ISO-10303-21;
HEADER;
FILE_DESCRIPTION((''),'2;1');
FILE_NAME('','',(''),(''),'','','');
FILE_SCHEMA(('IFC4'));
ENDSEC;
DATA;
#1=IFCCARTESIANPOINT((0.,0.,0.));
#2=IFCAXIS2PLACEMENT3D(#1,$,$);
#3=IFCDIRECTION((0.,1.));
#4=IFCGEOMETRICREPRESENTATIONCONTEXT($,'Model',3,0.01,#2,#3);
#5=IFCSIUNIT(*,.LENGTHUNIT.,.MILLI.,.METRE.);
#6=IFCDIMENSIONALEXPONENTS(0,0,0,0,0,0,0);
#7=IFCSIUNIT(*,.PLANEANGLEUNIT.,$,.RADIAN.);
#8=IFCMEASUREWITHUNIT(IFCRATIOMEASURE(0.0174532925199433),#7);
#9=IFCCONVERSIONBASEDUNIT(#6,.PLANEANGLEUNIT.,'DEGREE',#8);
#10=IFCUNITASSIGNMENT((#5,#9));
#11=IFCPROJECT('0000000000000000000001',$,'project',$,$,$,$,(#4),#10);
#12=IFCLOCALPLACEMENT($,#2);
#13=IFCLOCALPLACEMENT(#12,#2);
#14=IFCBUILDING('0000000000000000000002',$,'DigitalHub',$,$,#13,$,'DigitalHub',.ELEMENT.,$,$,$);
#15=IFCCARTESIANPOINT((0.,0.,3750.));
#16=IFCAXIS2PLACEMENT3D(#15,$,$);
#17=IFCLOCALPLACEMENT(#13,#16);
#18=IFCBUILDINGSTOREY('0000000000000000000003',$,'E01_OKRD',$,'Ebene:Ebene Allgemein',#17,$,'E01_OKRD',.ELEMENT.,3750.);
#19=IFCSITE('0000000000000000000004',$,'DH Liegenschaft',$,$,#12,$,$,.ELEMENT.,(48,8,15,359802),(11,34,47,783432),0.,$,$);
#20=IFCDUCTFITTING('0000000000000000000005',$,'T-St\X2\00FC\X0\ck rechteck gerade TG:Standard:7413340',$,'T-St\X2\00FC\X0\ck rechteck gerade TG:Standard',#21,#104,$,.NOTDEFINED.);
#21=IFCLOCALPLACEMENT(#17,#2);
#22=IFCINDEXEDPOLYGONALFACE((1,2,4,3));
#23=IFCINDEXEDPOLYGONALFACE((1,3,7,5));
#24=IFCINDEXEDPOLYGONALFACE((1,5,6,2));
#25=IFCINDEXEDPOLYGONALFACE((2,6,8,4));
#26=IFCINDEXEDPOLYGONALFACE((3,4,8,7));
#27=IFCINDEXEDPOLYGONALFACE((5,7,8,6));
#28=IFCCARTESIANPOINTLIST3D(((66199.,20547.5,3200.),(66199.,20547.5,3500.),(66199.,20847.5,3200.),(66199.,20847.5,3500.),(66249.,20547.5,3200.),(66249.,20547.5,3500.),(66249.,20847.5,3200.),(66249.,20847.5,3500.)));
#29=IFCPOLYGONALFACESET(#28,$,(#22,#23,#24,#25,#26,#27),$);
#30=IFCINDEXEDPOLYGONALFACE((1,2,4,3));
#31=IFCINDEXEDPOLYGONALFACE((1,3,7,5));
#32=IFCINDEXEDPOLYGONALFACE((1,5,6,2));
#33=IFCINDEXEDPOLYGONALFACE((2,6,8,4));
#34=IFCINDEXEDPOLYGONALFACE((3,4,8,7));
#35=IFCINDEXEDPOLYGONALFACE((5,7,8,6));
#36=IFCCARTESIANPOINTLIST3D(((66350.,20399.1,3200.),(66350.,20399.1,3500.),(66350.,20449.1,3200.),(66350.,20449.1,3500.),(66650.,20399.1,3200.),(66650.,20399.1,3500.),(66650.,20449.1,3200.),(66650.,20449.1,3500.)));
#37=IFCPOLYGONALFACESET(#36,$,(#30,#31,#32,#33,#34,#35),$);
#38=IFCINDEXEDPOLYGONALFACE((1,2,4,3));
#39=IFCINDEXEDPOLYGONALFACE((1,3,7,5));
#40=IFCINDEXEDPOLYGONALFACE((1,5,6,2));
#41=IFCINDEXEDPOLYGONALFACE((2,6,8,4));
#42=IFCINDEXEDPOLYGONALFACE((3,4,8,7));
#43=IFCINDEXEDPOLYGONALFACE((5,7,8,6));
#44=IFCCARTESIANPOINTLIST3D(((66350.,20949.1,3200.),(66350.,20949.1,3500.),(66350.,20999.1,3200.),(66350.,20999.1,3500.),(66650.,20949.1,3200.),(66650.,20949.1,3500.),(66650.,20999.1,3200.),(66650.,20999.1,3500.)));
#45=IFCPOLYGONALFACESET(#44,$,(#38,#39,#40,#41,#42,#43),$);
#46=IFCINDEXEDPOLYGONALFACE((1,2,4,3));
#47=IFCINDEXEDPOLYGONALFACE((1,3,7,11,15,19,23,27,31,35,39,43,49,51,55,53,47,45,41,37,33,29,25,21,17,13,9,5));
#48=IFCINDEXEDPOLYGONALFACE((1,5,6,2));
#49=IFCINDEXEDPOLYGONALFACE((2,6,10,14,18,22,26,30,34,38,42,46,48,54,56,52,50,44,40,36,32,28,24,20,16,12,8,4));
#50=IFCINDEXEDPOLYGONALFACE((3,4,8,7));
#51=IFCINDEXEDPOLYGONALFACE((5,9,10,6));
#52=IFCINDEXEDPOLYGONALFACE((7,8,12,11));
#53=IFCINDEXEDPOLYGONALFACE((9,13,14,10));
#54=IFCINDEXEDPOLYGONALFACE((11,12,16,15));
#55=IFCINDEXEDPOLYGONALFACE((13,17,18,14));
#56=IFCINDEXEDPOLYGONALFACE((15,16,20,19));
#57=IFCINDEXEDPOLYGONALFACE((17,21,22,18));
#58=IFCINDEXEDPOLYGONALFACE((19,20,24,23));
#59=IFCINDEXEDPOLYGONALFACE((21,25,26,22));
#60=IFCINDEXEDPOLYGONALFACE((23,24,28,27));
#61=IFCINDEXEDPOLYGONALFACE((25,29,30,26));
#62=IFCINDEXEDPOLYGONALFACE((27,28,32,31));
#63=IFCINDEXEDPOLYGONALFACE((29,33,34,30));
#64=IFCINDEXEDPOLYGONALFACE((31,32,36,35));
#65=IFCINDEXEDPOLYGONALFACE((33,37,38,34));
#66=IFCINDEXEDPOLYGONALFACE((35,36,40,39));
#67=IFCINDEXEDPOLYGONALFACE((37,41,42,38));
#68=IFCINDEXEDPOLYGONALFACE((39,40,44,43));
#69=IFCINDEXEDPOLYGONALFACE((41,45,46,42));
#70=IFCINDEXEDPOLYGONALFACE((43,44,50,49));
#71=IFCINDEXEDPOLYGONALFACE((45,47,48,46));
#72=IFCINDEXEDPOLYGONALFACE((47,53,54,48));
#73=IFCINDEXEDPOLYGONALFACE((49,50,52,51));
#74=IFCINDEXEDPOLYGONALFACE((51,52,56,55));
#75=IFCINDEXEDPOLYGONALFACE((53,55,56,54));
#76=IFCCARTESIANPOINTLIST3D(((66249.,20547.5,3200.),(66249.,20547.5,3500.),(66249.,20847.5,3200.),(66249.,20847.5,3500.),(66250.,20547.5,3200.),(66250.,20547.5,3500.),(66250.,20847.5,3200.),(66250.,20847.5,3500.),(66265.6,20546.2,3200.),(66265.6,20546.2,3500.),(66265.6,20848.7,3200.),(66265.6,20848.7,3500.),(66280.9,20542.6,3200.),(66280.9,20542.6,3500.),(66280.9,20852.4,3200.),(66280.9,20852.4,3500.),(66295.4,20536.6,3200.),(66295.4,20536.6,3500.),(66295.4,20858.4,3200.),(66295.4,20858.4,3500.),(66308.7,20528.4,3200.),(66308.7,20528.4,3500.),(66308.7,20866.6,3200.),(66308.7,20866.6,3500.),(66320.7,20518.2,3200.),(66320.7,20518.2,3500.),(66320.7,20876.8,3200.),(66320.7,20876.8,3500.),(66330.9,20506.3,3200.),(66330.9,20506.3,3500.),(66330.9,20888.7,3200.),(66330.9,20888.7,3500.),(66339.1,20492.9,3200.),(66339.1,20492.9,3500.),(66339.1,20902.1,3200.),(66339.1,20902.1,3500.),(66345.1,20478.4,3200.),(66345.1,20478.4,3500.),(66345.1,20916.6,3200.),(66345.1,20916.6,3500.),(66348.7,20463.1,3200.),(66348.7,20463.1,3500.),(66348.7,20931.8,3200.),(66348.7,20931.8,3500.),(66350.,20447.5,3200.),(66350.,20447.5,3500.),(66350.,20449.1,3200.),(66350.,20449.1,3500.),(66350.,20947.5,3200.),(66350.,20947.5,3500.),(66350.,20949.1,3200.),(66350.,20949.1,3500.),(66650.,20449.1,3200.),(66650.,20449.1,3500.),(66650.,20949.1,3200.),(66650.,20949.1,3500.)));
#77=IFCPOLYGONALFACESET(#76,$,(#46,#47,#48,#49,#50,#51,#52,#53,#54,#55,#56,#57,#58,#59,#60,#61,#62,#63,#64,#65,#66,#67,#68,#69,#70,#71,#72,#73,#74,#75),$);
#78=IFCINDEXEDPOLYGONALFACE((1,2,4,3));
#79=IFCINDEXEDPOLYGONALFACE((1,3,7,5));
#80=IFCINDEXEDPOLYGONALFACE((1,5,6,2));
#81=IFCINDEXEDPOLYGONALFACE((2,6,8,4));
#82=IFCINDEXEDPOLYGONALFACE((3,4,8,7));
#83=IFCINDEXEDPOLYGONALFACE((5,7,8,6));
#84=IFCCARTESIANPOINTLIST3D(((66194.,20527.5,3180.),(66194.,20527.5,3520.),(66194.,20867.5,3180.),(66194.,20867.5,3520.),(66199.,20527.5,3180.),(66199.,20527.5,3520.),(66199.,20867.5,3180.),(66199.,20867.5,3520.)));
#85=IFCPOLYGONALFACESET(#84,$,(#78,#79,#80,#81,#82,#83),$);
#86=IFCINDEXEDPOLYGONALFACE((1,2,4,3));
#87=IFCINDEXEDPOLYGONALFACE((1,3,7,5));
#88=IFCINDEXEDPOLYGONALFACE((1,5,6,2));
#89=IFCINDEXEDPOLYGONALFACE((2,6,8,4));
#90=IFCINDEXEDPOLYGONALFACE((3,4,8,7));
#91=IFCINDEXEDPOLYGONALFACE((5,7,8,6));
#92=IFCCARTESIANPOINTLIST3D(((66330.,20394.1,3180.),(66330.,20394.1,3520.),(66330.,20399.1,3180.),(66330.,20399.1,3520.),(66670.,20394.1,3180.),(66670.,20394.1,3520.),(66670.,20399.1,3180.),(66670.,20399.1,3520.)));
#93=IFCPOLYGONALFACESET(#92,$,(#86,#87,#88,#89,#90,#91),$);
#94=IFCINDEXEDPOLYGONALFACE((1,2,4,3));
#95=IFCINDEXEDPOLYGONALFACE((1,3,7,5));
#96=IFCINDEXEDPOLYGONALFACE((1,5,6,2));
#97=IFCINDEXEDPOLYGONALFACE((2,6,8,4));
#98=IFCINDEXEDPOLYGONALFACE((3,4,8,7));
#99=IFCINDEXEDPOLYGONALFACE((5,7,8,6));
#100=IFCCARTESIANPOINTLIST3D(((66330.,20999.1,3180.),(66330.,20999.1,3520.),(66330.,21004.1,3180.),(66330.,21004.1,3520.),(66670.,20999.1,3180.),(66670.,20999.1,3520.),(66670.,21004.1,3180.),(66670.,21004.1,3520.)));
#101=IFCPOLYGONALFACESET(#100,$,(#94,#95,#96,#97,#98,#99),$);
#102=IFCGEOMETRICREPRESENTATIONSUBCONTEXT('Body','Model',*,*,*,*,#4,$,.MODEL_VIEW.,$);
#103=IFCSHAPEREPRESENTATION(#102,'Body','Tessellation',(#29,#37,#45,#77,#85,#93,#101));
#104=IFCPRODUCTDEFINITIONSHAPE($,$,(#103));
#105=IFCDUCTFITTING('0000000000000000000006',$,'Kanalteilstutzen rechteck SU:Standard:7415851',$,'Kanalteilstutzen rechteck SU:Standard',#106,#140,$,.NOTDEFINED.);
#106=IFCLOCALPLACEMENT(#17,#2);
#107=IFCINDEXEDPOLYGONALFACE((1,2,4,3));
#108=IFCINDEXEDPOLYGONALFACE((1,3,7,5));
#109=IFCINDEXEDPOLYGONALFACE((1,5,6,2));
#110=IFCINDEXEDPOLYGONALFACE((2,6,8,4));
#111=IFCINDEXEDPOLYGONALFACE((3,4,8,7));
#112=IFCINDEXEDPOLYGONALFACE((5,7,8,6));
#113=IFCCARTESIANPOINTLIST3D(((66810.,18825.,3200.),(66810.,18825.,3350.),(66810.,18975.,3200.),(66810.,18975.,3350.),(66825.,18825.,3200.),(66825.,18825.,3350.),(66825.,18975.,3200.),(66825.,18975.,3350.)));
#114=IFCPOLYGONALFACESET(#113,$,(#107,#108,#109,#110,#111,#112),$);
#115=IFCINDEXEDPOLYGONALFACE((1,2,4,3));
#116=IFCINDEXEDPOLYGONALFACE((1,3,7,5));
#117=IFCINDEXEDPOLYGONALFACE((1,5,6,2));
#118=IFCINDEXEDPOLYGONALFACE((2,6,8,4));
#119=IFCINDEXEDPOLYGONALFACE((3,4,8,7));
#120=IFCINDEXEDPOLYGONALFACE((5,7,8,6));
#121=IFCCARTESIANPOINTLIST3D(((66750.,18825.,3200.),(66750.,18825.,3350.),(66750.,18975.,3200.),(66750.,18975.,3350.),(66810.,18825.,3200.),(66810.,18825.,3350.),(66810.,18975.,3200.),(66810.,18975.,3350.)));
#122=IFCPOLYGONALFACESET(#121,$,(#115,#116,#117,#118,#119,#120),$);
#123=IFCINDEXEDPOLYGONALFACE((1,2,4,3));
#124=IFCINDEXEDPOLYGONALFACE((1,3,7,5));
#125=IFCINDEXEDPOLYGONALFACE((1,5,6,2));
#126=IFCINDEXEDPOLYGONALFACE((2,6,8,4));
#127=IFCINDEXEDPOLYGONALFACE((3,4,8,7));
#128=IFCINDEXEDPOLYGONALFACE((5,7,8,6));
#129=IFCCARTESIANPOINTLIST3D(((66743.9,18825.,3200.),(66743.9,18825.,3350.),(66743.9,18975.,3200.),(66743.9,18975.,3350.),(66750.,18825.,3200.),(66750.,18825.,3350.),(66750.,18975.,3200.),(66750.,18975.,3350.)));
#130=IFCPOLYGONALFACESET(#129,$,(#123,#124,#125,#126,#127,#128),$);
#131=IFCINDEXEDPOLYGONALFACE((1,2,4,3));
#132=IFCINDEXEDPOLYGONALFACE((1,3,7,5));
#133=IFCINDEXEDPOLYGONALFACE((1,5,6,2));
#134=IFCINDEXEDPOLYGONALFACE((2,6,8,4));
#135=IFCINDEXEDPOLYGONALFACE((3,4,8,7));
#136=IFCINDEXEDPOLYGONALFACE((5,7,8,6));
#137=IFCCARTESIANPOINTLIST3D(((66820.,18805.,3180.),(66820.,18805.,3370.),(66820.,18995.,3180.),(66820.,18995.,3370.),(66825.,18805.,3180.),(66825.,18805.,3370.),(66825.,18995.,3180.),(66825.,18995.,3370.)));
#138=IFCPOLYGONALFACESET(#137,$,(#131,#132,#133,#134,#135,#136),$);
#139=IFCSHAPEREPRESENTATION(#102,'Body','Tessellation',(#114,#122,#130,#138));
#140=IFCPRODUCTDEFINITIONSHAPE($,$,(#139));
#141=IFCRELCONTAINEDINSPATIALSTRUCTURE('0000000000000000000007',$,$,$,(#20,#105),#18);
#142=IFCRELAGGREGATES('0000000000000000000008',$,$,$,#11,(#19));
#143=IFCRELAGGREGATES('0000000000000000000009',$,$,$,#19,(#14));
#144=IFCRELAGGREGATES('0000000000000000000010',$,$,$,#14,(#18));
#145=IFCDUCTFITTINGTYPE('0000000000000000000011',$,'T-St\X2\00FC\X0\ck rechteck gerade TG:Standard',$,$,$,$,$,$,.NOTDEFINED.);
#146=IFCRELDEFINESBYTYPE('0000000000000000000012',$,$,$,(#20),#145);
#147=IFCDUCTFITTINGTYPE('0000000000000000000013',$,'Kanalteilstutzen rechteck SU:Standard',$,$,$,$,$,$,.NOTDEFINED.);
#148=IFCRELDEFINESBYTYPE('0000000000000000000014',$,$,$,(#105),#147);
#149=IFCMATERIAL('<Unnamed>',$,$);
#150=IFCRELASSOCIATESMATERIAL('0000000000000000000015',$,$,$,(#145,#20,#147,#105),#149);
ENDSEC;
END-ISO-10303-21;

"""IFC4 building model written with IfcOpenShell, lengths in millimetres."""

from ifc_helpers import new_model, entity, si_unit, converted_unit, direction, frame, origin, place, context, subcontext, project, spatial, indexed_curve, outline, extrude, source, transform, mapped, material, type_object, type_shapes, element, save


model = new_model("IFC4")

# Units and contexts
model_context = context("Model", 3, precision=0.01, world=origin(), true_north=direction((0.0, 1.0)))
body_context = subcontext(model_context, "Body", "Model", "MODEL_VIEW")
ifc_project = project(units=[si_unit("LENGTHUNIT", "METRE", prefix="MILLI"), converted_unit("PLANEANGLEUNIT", "DEGREE", entity("IfcRatioMeasure", 0.0174532925199433), si_unit("PLANEANGLEUNIT", "RADIAN"), dimensions=[0, 0, 0, 0, 0, 0, 0])], contexts=[model_context])

# Site, building, storey
site_placement = place(None, origin())
site = spatial("IfcSite", under=ifc_project, at=site_placement, Name="DH Liegenschaft", CompositionType="ELEMENT", RefLatitude=(48, 8, 15, 359802), RefLongitude=(11, 34, 47, 783432), RefElevation=0.0)
building_placement = place(site_placement, origin())
building = spatial("IfcBuilding", under=site, at=building_placement, Name="DigitalHub", LongName="DigitalHub", CompositionType="ELEMENT")
storey_placement = place(building_placement, frame((0.0, 0.0, 3750.0)))
storey = spatial("IfcBuildingStorey", under=building, at=storey_placement, Name="E01_OKRD", ObjectType="Ebene:Ebene Allgemein", LongName="E01_OKRD", CompositionType="ELEMENT", Elevation=3750.0)

# Shared definitions
ifc_material_1 = material(Name="<Unnamed>")

# Duct fittings
duct_fitting_type_1 = type_object("IfcDuctFittingType", Name="T-Stück rechteck gerade TG:Standard", PredefinedType="NOTDEFINED", material=ifc_material_1)
shared_shape_1 = source(origin(), body_context, "Body", "SweptSolid", [
    extrude(outline(indexed_curve([(-25.0, -150.0), (25.0, -150.0), (25.0, 150.0), (-25.0, 150.0), (-25.0, -150.0)], self_intersect=False)), frame((0.0, -276.0, -150.0), z_axis=(0.0, 0.0, 1.0), x_axis=(0.0, -1.0, 0.0)), (0.0, 0.0, 1.0), 300.0),
    extrude(outline(indexed_curve([(-25.0, -150.0), (25.0, -150.0), (25.0, 150.0), (-25.0, 150.0), (-25.0, -150.0)], self_intersect=False)), frame((273.4, 0.0, -150.0), z_axis=(0.0, 0.0, 1.0), x_axis=(-1.0, 0.0, 0.0)), (0.0, 0.0, 1.0), 300.0),
    extrude(outline(indexed_curve([(-25.0, -150.0), (25.0, -150.0), (25.0, 150.0), (-25.0, 150.0), (-25.0, -150.0)], self_intersect=False)), frame((-276.6, 0.0, -150.0)), (0.0, 0.0, 1.0), 300.0),
    extrude(outline(indexed_curve([(-250.6, -19.8), (-235.0, -21.0), (-219.7, -24.7), (-205.2, -30.7), (-191.9, -38.9), (-179.9, -49.1), (-169.7, -61.0), (-161.5, -74.4), (-155.5, -88.9), (-151.9, -104.2), (-150.6, -119.8), (-150.6, -120.8), (149.4, -120.8), (149.4, -119.8), (150.6, -104.2), (154.3, -88.9), (160.3, -74.4), (168.5, -61.0), (178.6, -49.1), (190.6, -38.9), (204.0, -30.7), (218.5, -24.7), (233.7, -21.0), (249.4, -19.8), (251.0, -19.8), (251.0, 280.2), (-249.0, 280.2), (-249.0, -19.8), (-250.6, -19.8)], self_intersect=False)), frame((-0.6, -130.2, -150.0), z_axis=(0.0, 0.0, -1.0), x_axis=(-1.0, 0.0, 0.0)), (0.0, 0.0, -1.0), 300.0),
    extrude(outline(indexed_curve([(-2.5, -170.0), (2.5, -170.0), (2.5, 170.0), (-2.5, 170.0), (-2.5, -170.0)], self_intersect=False)), frame((0.0, -303.5, -170.0), z_axis=(0.0, 0.0, 1.0), x_axis=(0.0, 1.0, 0.0)), (0.0, 0.0, 1.0), 340.0),
    extrude(outline(indexed_curve([(-2.5, -170.0), (2.5, -170.0), (2.5, 170.0), (-2.5, 170.0), (-2.5, -170.0)], self_intersect=False)), frame((300.9, 0.0, -170.0), z_axis=(0.0, 0.0, 1.0), x_axis=(-1.0, 0.0, 0.0)), (0.0, 0.0, 1.0), 340.0),
    extrude(outline(indexed_curve([(-2.5, -170.0), (2.5, -170.0), (2.5, 170.0), (-2.5, 170.0), (-2.5, -170.0)], self_intersect=False)), frame((-304.1, 0.0, -170.0), z_axis=(0.0, 0.0, 1.0), x_axis=(-1.0, 0.0, 0.0)), (0.0, 0.0, 1.0), 340.0),
])
type_shapes(duct_fitting_type_1, [shared_shape_1])
duct_fitting_1_placement = place(storey_placement, frame((66500.0, 20697.5, 3350.0), z_axis=(0.0, 0.0, 1.0), x_axis=(0.0, -1.0, 0.0)))
element("IfcDuctFitting", 1, at=duct_fitting_1_placement, inside=storey, type_object=duct_fitting_type_1, material=ifc_material_1, Name="T-Stück rechteck gerade TG:Standard:7413340", ObjectType="T-Stück rechteck gerade TG:Standard", PredefinedType="NOTDEFINED", context=body_context, shape_type="MappedRepresentation", body=[
    mapped(shared_shape_1, transform((0.0, 0.0, 0.0), scale=1.0)),
])
duct_fitting_type_2 = type_object("IfcDuctFittingType", Name="Kanalteilstutzen rechteck SU:Standard", PredefinedType="NOTDEFINED", material=ifc_material_1)
shared_shape_2 = source(origin(), body_context, "Body", "SweptSolid", [
    extrude(outline(indexed_curve([(-75.0, -7.5), (75.0, -7.5), (75.0, 7.5), (-75.0, 7.5), (-75.0, -7.5)], self_intersect=False)), frame((67.5, 0.0, -75.0), z_axis=(0.0, 0.0, 1.0), x_axis=(0.0, -1.0, 0.0)), (0.0, 0.0, 1.0), 150.0),
    extrude(outline(indexed_curve([(-75.0, -30.0), (75.0, -30.0), (75.0, 30.0), (-75.0, 30.0), (-75.0, -30.0)], self_intersect=False)), frame((30.0, 0.0, -75.0), z_axis=(0.0, 0.0, 1.0), x_axis=(0.0, -1.0, 0.0)), (0.0, 0.0, 1.0), 150.0),
    extrude(outline(indexed_curve([(-75.0, -3.0), (75.0, -3.0), (75.0, 3.0), (-75.0, 3.0), (-75.0, -3.0)], self_intersect=False)), frame((-3.0, 0.0, -75.0), z_axis=(0.0, 0.0, 1.0), x_axis=(0.0, -1.0, 0.0)), (0.0, 0.0, 1.0), 150.0),
    extrude(outline(indexed_curve([(-95.0, -2.5), (95.0, -2.5), (95.0, 2.5), (-95.0, 2.5), (-95.0, -2.5)], self_intersect=False)), frame((72.5, 0.0, -95.0), z_axis=(0.0, 0.0, 1.0), x_axis=(0.0, -1.0, 0.0)), (0.0, 0.0, 1.0), 190.0),
])
type_shapes(duct_fitting_type_2, [shared_shape_2])
duct_fitting_2_placement = place(storey_placement, frame((66750.0, 18900.0, 3275.0), z_axis=(0.000013, 0.0, -1.0), x_axis=(1.0, 0.0, 0.000013)))
element("IfcDuctFitting", 2, at=duct_fitting_2_placement, inside=storey, type_object=duct_fitting_type_2, material=ifc_material_1, Name="Kanalteilstutzen rechteck SU:Standard:7415851", ObjectType="Kanalteilstutzen rechteck SU:Standard", PredefinedType="NOTDEFINED", context=body_context, shape_type="MappedRepresentation", body=[
    mapped(shared_shape_2, transform((0.0, 0.0, 0.0), scale=1.0)),
])

save(model, "model.ifc")
